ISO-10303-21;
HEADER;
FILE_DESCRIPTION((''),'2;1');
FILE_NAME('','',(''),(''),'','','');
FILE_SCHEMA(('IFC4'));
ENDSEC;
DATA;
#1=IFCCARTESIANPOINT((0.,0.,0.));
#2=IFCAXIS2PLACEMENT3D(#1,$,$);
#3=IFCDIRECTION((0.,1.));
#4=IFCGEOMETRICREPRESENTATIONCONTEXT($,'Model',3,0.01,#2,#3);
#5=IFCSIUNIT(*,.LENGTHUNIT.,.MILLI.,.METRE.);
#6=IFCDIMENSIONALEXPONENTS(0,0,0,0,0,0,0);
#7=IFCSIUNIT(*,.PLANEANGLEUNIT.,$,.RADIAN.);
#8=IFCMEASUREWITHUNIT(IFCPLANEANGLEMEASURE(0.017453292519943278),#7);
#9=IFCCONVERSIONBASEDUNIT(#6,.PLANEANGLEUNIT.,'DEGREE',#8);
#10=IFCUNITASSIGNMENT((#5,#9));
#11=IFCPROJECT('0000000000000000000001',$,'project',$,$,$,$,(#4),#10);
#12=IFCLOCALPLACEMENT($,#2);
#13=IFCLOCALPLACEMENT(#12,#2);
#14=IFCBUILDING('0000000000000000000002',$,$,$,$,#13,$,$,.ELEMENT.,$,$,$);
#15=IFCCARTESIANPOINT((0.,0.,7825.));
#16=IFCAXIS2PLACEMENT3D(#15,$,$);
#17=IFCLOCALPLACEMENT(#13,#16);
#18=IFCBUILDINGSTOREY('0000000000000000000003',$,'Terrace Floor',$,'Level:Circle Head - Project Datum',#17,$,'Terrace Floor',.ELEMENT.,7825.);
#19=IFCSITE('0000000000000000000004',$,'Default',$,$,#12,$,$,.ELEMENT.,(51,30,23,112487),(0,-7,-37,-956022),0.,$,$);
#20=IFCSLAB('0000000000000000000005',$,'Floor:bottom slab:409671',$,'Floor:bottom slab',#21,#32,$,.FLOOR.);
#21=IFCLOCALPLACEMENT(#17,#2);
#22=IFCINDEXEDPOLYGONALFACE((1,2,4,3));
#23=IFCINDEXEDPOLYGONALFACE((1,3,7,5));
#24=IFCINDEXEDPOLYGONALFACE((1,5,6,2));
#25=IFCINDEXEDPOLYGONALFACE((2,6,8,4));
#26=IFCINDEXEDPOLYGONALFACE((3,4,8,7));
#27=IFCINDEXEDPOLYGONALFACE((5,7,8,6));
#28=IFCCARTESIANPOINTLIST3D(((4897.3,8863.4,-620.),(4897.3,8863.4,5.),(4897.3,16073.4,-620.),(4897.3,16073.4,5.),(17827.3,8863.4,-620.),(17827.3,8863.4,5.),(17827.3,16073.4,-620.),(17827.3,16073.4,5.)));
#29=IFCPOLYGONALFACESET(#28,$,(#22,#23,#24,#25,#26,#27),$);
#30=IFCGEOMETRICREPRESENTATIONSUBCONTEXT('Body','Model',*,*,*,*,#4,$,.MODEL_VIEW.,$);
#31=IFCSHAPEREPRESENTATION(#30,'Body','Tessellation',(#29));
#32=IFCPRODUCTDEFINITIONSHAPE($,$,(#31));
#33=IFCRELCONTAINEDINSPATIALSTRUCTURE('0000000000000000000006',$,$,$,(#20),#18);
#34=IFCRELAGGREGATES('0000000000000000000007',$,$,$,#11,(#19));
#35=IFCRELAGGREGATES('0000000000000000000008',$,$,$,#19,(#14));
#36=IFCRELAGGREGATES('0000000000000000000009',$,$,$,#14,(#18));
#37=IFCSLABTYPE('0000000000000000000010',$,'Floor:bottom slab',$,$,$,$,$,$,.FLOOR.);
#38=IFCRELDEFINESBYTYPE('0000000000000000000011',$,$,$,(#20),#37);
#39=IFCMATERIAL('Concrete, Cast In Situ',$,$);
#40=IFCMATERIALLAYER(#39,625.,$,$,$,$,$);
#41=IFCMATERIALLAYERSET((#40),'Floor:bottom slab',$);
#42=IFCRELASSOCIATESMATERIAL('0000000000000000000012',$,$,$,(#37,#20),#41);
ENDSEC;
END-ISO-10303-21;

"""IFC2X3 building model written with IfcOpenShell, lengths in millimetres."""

from ifc_helpers import new_model, entity, si_unit, converted_unit, direction, frame, frame_2d, origin, place, context, subcontext, project, spatial, rectangle, extrude, material, layer, layer_set, layer_usage, type_object, element, save


model = new_model("IFC2X3")

# Units and contexts
model_context = context("Model", 3, precision=0.01, world=origin(), true_north=direction((0.0, 1.0)))
body_context = subcontext(model_context, "Body", "Model", "MODEL_VIEW")
ifc_project = project(units=[si_unit("LENGTHUNIT", "METRE", prefix="MILLI"), converted_unit("PLANEANGLEUNIT", "DEGREE", entity("IfcPlaneAngleMeasure", 0.017453292519943278), si_unit("PLANEANGLEUNIT", "RADIAN"), dimensions=[0, 0, 0, 0, 0, 0, 0])], contexts=[model_context])

# Site, building, storey
site_placement = place(None, origin())
site = spatial("IfcSite", under=ifc_project, at=site_placement, Name="Default", CompositionType="ELEMENT", RefLatitude=(51, 30, 23, 112487), RefLongitude=(0, -7, -37, -956022), RefElevation=0.0)
building_placement = place(site_placement, origin())
building = spatial("IfcBuilding", under=site, at=building_placement, CompositionType="ELEMENT")
storey_placement = place(building_placement, frame((0.0, 0.0, 7825.0)))
storey = spatial("IfcBuildingStorey", under=building, at=storey_placement, Name="Terrace Floor", ObjectType="Level:Circle Head - Project Datum", LongName="Terrace Floor", CompositionType="ELEMENT", Elevation=7825.0)

# Slab
ifc_material = material(Name="Concrete, Cast In Situ")
ifc_layer = layer(ifc_material, 625.0)
ifc_layer_set = layer_set([ifc_layer], Name="Floor:bottom slab")
ifc_layer_usage = layer_usage(ifc_layer_set, "AXIS3", "POSITIVE", 0.0)
slab_type = type_object("IfcSlabType", Name="Floor:bottom slab", PredefinedType="FLOOR", material=ifc_layer_set)
slab_placement = place(storey_placement, origin())
element("IfcSlab", 1, at=slab_placement, inside=storey, type_object=slab_type, material=ifc_layer_usage, Name="Floor:bottom slab:409671", ObjectType="Floor:bottom slab", PredefinedType="FLOOR", context=body_context, shape_type="SweptSolid", body=[
    extrude(rectangle(XDim=7210.0, YDim=12930.0, at=frame_2d((0.0, 0.0), x_axis=(1.0, 0.0))), frame((11362.3, 12468.4, 5.0), z_axis=(0.0, 0.0, -1.0), x_axis=(0.0, 1.0, 0.0)), (0.0, 0.0, 1.0), 625.0),
])

save(model, "model.ifc")
